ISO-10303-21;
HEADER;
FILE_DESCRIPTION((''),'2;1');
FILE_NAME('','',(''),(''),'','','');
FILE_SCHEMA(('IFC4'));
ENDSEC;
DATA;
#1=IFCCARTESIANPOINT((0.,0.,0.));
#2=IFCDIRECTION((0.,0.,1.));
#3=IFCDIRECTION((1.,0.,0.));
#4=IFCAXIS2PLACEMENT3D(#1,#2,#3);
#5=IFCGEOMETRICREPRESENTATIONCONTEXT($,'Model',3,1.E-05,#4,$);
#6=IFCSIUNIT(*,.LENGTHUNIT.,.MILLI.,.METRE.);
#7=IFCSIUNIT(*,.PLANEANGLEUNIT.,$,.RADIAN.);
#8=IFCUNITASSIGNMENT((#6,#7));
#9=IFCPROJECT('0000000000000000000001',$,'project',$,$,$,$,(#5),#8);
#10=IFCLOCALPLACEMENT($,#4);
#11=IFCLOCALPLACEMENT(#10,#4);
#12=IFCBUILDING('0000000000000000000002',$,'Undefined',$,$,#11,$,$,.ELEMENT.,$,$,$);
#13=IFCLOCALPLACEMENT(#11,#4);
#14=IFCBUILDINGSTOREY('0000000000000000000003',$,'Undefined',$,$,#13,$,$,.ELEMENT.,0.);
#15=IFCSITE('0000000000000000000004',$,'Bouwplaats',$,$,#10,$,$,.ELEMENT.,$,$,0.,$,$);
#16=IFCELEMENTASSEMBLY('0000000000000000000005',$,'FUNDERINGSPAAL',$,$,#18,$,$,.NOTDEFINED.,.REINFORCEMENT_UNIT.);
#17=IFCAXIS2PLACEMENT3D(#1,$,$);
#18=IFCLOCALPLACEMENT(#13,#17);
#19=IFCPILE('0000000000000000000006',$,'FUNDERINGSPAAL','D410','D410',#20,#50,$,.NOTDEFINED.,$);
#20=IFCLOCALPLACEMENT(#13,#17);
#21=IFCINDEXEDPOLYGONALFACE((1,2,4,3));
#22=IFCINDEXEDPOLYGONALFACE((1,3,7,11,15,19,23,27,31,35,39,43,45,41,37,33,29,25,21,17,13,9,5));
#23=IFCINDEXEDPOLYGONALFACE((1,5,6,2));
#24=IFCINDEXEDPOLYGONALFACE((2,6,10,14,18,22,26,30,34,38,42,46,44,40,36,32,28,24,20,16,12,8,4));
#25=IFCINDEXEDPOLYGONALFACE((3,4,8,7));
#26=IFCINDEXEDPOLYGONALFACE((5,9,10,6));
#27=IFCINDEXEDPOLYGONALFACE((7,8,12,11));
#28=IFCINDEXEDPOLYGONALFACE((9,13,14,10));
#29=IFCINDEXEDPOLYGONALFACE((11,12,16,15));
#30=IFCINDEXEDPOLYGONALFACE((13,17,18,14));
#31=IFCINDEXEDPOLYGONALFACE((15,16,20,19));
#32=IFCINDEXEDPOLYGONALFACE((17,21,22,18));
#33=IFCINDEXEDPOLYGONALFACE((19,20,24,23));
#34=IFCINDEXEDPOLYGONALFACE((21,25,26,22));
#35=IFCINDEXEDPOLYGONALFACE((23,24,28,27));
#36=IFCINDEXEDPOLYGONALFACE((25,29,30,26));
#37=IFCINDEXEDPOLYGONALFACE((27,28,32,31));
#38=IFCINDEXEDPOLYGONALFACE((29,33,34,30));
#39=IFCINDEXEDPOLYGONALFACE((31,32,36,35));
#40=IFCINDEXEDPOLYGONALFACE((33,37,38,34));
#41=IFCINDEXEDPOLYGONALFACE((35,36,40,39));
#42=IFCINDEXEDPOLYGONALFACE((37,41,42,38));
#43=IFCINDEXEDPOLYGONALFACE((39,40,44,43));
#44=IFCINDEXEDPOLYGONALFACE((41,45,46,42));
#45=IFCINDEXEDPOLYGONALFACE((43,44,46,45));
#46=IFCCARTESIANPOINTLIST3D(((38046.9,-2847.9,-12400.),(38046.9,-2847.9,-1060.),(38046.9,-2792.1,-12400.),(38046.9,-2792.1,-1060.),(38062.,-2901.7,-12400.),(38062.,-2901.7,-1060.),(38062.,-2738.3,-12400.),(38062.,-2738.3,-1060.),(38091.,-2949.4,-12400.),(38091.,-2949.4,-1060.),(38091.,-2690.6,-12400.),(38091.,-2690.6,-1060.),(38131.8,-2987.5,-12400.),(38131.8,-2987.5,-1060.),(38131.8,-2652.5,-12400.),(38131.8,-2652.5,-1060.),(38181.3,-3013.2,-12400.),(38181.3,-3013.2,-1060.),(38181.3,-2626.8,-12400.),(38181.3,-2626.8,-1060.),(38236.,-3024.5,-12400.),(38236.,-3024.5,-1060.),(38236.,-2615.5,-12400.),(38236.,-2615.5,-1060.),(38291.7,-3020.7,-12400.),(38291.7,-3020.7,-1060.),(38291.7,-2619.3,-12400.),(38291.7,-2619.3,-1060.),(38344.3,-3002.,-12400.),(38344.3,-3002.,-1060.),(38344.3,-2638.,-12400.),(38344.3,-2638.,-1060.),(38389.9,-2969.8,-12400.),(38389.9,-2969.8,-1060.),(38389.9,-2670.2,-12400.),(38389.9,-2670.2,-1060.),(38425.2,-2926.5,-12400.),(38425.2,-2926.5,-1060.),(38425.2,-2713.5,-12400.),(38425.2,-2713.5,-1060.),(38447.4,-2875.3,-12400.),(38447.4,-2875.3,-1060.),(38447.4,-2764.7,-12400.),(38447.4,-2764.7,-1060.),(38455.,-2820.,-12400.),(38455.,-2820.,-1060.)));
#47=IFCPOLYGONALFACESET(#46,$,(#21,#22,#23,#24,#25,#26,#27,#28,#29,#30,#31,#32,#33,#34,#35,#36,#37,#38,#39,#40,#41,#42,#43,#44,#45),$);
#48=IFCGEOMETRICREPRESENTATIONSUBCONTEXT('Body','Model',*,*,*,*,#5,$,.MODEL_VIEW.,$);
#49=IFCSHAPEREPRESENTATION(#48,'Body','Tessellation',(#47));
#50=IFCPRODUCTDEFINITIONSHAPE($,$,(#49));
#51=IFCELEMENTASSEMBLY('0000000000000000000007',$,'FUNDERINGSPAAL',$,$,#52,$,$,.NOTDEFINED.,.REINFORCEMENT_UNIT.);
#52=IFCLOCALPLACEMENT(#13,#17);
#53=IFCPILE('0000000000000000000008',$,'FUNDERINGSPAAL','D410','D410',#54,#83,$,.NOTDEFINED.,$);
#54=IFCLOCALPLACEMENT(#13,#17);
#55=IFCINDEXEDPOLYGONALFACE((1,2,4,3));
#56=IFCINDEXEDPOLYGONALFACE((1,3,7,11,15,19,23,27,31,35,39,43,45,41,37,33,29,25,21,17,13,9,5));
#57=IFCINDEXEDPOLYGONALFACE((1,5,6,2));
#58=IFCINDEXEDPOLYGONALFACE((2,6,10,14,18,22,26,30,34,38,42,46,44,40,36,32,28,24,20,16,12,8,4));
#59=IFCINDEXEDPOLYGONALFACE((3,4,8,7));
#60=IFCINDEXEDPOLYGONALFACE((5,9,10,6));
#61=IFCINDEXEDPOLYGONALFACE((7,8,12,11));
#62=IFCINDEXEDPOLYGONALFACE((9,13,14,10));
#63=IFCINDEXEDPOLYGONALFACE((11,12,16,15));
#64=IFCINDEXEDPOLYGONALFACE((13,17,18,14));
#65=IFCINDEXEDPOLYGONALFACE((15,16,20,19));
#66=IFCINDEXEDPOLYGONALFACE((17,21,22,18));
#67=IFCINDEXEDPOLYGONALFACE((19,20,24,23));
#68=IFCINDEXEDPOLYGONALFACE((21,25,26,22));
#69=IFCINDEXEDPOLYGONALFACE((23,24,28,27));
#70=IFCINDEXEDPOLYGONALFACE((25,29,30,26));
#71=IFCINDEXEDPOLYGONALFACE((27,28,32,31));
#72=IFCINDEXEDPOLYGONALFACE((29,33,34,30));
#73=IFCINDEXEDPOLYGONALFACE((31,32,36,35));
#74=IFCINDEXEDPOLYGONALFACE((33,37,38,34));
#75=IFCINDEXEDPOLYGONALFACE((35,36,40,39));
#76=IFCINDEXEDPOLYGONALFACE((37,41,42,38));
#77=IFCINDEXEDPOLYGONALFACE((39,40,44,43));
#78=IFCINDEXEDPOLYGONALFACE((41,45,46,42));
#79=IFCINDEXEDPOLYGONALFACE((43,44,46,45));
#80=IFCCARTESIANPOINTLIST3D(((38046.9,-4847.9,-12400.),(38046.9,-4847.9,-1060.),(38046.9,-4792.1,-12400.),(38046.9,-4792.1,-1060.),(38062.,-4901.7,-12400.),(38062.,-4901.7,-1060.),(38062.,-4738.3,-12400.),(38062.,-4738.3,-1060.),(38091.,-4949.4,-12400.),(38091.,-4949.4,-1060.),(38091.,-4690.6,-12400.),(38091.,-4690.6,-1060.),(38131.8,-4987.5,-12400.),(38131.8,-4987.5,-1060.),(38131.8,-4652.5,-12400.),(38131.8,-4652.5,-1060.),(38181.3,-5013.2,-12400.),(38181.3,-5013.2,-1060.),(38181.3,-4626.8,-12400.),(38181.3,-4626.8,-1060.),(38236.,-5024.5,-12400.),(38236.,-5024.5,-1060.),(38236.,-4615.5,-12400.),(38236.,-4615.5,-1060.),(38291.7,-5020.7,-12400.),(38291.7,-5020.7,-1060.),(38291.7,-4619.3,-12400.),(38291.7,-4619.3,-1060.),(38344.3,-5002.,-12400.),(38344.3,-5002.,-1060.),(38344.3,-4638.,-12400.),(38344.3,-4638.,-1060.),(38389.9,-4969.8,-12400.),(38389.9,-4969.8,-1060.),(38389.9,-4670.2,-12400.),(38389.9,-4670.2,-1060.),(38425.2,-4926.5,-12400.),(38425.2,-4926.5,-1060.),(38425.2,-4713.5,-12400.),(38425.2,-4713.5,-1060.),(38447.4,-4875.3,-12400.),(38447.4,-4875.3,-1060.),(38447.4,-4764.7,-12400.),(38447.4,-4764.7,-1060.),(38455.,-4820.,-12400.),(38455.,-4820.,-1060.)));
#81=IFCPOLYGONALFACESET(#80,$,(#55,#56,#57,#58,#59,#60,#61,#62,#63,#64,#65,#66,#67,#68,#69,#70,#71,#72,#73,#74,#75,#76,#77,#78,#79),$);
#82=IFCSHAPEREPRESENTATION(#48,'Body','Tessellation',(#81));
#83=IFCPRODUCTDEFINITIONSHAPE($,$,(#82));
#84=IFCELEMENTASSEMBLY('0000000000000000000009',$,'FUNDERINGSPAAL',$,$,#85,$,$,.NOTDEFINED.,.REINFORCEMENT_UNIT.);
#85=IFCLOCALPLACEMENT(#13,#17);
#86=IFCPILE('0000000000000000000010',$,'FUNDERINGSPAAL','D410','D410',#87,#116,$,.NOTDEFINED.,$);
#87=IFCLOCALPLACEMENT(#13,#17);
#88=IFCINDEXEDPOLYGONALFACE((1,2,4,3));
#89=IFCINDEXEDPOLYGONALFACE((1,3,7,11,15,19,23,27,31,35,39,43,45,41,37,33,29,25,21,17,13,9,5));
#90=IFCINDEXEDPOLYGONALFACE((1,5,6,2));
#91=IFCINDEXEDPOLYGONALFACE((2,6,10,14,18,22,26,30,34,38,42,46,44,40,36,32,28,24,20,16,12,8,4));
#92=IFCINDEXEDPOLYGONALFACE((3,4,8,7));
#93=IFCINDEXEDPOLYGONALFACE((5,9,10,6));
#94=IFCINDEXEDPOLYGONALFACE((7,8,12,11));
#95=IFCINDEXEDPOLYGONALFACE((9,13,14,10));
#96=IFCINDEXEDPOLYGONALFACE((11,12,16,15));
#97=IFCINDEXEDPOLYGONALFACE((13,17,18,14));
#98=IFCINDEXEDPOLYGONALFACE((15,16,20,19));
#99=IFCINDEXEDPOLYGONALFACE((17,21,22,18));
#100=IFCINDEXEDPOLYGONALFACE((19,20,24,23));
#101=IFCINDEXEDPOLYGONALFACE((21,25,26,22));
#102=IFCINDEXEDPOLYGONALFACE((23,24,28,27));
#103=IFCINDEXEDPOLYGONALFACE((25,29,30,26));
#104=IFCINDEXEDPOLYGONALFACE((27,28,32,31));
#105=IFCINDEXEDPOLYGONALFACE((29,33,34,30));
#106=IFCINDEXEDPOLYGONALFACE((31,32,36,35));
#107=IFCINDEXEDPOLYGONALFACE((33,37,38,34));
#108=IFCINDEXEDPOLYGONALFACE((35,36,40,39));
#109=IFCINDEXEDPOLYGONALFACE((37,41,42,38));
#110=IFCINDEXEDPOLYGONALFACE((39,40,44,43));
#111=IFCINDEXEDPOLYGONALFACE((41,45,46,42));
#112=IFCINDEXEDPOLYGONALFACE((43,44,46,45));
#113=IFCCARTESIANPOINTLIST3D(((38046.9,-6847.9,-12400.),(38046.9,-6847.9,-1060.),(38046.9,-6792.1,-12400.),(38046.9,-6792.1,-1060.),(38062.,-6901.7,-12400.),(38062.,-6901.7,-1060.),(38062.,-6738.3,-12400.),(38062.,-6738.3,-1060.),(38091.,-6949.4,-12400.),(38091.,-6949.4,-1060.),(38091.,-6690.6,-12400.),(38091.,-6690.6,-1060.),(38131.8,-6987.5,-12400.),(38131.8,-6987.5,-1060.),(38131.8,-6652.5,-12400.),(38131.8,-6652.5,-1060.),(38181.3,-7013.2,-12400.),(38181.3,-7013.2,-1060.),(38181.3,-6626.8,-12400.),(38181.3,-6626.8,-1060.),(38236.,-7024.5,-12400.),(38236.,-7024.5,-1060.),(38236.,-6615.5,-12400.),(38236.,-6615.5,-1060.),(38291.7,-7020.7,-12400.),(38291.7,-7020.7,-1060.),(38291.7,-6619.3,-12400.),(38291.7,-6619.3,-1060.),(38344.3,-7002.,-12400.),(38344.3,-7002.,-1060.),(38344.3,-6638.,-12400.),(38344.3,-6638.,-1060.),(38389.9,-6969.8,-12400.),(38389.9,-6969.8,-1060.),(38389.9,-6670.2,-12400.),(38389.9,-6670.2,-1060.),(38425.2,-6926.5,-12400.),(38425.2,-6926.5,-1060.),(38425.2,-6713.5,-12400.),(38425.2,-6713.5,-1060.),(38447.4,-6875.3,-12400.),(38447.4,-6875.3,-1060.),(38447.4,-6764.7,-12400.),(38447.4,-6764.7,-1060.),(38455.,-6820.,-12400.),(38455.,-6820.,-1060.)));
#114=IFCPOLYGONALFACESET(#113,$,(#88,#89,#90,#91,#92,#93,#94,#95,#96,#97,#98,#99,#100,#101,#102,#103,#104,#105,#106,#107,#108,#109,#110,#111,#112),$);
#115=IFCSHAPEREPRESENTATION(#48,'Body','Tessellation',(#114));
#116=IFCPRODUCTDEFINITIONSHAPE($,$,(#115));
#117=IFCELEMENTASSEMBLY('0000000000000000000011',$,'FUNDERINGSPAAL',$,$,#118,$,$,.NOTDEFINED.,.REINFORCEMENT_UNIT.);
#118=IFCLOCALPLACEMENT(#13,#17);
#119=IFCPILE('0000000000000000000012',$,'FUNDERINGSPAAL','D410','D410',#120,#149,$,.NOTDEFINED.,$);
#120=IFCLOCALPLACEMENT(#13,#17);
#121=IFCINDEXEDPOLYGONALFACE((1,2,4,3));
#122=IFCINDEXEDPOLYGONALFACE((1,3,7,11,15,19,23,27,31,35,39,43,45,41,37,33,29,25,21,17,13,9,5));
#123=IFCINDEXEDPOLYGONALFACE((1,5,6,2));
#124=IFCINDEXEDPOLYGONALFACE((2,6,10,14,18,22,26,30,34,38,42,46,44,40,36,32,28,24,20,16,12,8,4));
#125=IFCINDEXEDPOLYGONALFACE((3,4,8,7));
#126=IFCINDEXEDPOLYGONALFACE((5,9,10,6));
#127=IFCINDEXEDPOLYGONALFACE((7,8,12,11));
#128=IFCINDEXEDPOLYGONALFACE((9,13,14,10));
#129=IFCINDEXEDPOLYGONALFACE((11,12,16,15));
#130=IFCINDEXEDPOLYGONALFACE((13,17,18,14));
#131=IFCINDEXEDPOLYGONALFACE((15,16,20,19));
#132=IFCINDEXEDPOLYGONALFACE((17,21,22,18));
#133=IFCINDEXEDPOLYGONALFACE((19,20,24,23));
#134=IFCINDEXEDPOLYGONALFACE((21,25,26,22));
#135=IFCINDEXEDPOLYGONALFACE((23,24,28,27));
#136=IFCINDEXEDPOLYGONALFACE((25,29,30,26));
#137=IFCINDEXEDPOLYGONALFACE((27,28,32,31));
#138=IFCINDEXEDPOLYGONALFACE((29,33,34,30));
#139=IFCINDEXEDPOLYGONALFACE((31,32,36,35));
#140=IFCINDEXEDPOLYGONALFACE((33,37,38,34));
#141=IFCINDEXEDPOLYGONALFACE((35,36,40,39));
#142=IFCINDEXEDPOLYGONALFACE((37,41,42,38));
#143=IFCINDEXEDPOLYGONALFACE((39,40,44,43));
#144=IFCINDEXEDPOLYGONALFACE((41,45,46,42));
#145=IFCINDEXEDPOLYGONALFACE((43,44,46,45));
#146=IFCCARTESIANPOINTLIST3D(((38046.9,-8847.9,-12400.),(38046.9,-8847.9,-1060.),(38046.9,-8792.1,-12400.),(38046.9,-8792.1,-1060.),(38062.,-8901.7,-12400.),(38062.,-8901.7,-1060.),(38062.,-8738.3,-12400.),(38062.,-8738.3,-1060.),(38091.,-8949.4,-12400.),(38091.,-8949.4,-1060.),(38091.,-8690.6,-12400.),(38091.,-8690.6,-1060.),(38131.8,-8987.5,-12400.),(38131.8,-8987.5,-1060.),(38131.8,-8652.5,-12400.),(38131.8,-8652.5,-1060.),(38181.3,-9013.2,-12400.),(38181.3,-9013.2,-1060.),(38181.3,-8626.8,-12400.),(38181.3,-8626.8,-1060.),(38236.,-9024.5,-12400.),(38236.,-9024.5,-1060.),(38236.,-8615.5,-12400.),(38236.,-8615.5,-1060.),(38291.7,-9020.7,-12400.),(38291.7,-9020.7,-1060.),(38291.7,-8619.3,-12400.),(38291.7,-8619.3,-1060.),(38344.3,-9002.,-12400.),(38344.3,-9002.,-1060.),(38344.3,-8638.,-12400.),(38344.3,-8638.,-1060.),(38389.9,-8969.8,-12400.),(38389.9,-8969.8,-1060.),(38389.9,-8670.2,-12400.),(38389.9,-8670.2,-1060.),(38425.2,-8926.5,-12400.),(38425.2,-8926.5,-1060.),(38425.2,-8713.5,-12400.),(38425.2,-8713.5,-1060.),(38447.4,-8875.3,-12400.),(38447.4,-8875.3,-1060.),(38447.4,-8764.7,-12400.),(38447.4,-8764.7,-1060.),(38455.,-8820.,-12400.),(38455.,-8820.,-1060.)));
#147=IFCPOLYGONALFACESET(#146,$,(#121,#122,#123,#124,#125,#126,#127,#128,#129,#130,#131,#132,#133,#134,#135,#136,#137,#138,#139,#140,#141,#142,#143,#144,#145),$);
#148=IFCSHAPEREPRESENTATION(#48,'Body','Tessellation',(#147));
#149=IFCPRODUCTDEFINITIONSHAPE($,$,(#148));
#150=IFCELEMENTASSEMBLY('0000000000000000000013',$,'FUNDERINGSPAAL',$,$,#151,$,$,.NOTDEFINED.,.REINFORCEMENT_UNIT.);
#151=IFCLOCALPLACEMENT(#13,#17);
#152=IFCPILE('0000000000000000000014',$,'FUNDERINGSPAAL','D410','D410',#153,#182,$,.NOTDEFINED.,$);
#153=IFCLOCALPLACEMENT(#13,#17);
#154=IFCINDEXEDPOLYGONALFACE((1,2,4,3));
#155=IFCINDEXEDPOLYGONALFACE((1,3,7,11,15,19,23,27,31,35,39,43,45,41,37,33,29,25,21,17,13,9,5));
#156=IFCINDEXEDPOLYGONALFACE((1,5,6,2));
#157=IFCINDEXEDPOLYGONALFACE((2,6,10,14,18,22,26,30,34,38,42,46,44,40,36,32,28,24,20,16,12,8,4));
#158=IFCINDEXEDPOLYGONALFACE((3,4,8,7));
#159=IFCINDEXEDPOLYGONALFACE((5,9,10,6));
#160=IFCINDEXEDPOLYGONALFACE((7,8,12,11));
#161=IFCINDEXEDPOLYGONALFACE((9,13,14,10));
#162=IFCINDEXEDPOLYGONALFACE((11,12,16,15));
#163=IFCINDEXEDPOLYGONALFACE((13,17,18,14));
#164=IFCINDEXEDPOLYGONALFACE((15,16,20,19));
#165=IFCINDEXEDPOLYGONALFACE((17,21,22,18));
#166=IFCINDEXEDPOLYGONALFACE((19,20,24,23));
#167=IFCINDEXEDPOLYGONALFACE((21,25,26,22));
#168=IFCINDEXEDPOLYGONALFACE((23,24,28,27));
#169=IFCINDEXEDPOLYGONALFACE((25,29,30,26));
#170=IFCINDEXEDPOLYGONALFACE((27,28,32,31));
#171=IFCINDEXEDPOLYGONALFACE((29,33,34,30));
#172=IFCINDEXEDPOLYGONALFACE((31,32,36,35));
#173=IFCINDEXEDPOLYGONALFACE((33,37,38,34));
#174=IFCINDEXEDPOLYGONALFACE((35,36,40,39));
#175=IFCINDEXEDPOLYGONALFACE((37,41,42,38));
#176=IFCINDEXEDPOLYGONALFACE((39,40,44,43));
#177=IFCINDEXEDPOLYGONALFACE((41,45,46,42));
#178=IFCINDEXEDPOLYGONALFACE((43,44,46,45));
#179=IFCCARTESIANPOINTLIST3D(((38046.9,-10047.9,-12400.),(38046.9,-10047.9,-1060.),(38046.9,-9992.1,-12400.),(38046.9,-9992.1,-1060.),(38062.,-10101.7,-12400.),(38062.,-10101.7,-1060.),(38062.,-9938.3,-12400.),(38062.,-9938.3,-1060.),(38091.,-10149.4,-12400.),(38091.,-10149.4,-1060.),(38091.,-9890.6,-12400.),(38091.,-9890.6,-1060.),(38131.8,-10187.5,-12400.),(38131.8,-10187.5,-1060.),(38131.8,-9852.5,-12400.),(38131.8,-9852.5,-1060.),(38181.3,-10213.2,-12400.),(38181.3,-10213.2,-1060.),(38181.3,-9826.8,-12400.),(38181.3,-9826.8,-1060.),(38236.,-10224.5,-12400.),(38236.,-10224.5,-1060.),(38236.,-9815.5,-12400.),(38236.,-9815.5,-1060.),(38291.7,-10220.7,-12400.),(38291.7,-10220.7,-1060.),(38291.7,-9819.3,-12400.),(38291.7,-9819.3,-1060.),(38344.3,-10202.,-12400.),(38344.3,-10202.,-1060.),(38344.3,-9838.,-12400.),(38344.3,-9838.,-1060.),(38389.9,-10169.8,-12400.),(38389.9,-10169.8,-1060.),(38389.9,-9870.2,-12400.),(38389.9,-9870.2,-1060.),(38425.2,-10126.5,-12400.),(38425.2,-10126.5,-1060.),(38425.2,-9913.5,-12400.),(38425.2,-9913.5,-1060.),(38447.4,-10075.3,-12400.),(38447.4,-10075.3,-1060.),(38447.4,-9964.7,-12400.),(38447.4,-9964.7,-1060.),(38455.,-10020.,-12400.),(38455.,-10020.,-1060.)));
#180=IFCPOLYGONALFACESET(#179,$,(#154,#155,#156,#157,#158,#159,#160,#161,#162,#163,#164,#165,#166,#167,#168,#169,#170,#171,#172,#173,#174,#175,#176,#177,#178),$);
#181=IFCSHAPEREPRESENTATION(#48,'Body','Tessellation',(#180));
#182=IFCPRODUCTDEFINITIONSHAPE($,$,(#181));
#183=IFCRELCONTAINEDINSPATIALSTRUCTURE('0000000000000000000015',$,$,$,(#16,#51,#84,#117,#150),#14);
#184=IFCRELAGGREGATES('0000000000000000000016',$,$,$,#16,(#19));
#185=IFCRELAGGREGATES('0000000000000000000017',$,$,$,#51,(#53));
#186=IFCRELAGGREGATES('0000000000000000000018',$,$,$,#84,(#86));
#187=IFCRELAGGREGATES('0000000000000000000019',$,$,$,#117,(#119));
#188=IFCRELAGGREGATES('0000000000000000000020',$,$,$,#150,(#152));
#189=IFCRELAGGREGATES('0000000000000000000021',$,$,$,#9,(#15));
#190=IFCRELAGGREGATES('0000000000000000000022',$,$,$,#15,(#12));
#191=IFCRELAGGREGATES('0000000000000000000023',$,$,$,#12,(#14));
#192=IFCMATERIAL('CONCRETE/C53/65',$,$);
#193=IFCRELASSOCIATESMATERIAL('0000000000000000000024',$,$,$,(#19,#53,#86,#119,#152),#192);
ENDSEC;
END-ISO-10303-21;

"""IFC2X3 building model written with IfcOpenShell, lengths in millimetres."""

from ifc_helpers import new_model, si_unit, frame, origin_with_axes, origin_2d_with_axis, place, context, subcontext, project, spatial, circle, extrude, clip, halfspace, material, element, aggregate, save


model = new_model("IFC2X3")

# Units and contexts
model_context = context("Model", 3, precision=1e-05, world=origin_with_axes())
body_context = subcontext(model_context, "Body", "Model", "MODEL_VIEW")
ifc_project = project(units=[si_unit("LENGTHUNIT", "METRE", prefix="MILLI"), si_unit("PLANEANGLEUNIT", "RADIAN")], contexts=[model_context])

# Site, building, storey
site_placement = place(None, origin_with_axes())
site = spatial("IfcSite", under=ifc_project, at=site_placement, Name="Bouwplaats", CompositionType="ELEMENT", RefElevation=0.0)
building_placement = place(site_placement, origin_with_axes())
building = spatial("IfcBuilding", under=site, at=building_placement, Name="Undefined", CompositionType="ELEMENT")
storey_placement = place(building_placement, origin_with_axes())
storey = spatial("IfcBuildingStorey", under=building, at=storey_placement, Name="Undefined", CompositionType="ELEMENT", Elevation=0.0)

# Element assemblies, piles
assembly_1_placement = place(storey_placement, origin_with_axes())
assembly_1 = element("IfcElementAssembly", 1, at=assembly_1_placement, inside=storey, Name="FUNDERINGSPAAL", AssemblyPlace="NOTDEFINED", PredefinedType="REINFORCEMENT_UNIT")
ifc_material_1 = material(Name="CONCRETE/C53/65")
pile_1_placement = place(assembly_1_placement, frame((38250.0, -2820.0, -1060.0), z_axis=(0.0, 1.0, 0.0), x_axis=(0.0, 0.0, -1.0)))
pile_1 = element("IfcPile", 2, at=pile_1_placement, material=ifc_material_1, Name="FUNDERINGSPAAL", Description="D410", ObjectType="D410", PredefinedType="NOTDEFINED", context=body_context, shape_type="Clipping", body=[
    clip(extrude(circle(Radius=205.0, at=origin_2d_with_axis()), frame((11340.0, 0.0, 0.0), z_axis=(-1.0, 0.0, 0.0), x_axis=(0.0, -1.0, 0.0)), (0.0, 0.0, 1.0), 11340.0), halfspace(frame((0.0, 205.0, -205.0), z_axis=(-1.0, 0.0, 0.0), x_axis=(0.0, 0.0, 1.0)), False)),
])
aggregate(assembly_1, [pile_1])
assembly_2_placement = place(storey_placement, origin_with_axes())
assembly_2 = element("IfcElementAssembly", 3, at=assembly_2_placement, inside=storey, Name="FUNDERINGSPAAL", AssemblyPlace="NOTDEFINED", PredefinedType="REINFORCEMENT_UNIT")
pile_2_placement = place(assembly_2_placement, frame((38250.0, -4820.0, -1060.0), z_axis=(0.0, 1.0, 0.0), x_axis=(0.0, 0.0, -1.0)))
pile_2 = element("IfcPile", 4, at=pile_2_placement, material=ifc_material_1, Name="FUNDERINGSPAAL", Description="D410", ObjectType="D410", PredefinedType="NOTDEFINED", context=body_context, shape_type="Clipping", body=[
    clip(extrude(circle(Radius=205.0, at=origin_2d_with_axis()), frame((11340.0, 0.0, 0.0), z_axis=(-1.0, 0.0, 0.0), x_axis=(0.0, -1.0, 0.0)), (0.0, 0.0, 1.0), 11340.0), halfspace(frame((0.0, 205.0, -205.0), z_axis=(-1.0, 0.0, 0.0), x_axis=(0.0, 0.0, 1.0)), False)),
])
aggregate(assembly_2, [pile_2])
assembly_3_placement = place(storey_placement, origin_with_axes())
assembly_3 = element("IfcElementAssembly", 5, at=assembly_3_placement, inside=storey, Name="FUNDERINGSPAAL", AssemblyPlace="NOTDEFINED", PredefinedType="REINFORCEMENT_UNIT")
pile_3_placement = place(assembly_3_placement, frame((38250.0, -6820.0, -1060.0), z_axis=(0.0, 1.0, 0.0), x_axis=(0.0, 0.0, -1.0)))
pile_3 = element("IfcPile", 6, at=pile_3_placement, material=ifc_material_1, Name="FUNDERINGSPAAL", Description="D410", ObjectType="D410", PredefinedType="NOTDEFINED", context=body_context, shape_type="Clipping", body=[
    clip(extrude(circle(Radius=205.0, at=origin_2d_with_axis()), frame((11340.0, 0.0, 0.0), z_axis=(-1.0, 0.0, 0.0), x_axis=(0.0, -1.0, 0.0)), (0.0, 0.0, 1.0), 11340.0), halfspace(frame((0.0, 205.0, -205.0), z_axis=(-1.0, 0.0, 0.0), x_axis=(0.0, 0.0, 1.0)), False)),
])
aggregate(assembly_3, [pile_3])
assembly_4_placement = place(storey_placement, origin_with_axes())
assembly_4 = element("IfcElementAssembly", 7, at=assembly_4_placement, inside=storey, Name="FUNDERINGSPAAL", AssemblyPlace="NOTDEFINED", PredefinedType="REINFORCEMENT_UNIT")
pile_4_placement = place(assembly_4_placement, frame((38250.0, -8820.0, -1060.0), z_axis=(0.0, 1.0, 0.0), x_axis=(0.0, 0.0, -1.0)))
pile_4 = element("IfcPile", 8, at=pile_4_placement, material=ifc_material_1, Name="FUNDERINGSPAAL", Description="D410", ObjectType="D410", PredefinedType="NOTDEFINED", context=body_context, shape_type="Clipping", body=[
    clip(extrude(circle(Radius=205.0, at=origin_2d_with_axis()), frame((11340.0, 0.0, 0.0), z_axis=(-1.0, 0.0, 0.0), x_axis=(0.0, -1.0, 0.0)), (0.0, 0.0, 1.0), 11340.0), halfspace(frame((0.0, 205.0, -205.0), z_axis=(-1.0, 0.0, 0.0), x_axis=(0.0, 0.0, 1.0)), False)),
])
aggregate(assembly_4, [pile_4])
assembly_5_placement = place(storey_placement, origin_with_axes())
assembly_5 = element("IfcElementAssembly", 9, at=assembly_5_placement, inside=storey, Name="FUNDERINGSPAAL", AssemblyPlace="NOTDEFINED", PredefinedType="REINFORCEMENT_UNIT")
pile_5_placement = place(assembly_5_placement, frame((38250.0, -10020.0, -1060.0), z_axis=(0.0, 1.0, 0.0), x_axis=(0.0, 0.0, -1.0)))
pile_5 = element("IfcPile", 10, at=pile_5_placement, material=ifc_material_1, Name="FUNDERINGSPAAL", Description="D410", ObjectType="D410", PredefinedType="NOTDEFINED", context=body_context, shape_type="Clipping", body=[
    clip(extrude(circle(Radius=205.0, at=origin_2d_with_axis()), frame((11340.0, 0.0, 0.0), z_axis=(-1.0, 0.0, 0.0), x_axis=(0.0, -1.0, 0.0)), (0.0, 0.0, 1.0), 11340.0), halfspace(frame((0.0, 205.0, -205.0), z_axis=(-1.0, 0.0, 0.0), x_axis=(0.0, 0.0, 1.0)), False)),
])
aggregate(assembly_5, [pile_5])

save(model, "model.ifc")
